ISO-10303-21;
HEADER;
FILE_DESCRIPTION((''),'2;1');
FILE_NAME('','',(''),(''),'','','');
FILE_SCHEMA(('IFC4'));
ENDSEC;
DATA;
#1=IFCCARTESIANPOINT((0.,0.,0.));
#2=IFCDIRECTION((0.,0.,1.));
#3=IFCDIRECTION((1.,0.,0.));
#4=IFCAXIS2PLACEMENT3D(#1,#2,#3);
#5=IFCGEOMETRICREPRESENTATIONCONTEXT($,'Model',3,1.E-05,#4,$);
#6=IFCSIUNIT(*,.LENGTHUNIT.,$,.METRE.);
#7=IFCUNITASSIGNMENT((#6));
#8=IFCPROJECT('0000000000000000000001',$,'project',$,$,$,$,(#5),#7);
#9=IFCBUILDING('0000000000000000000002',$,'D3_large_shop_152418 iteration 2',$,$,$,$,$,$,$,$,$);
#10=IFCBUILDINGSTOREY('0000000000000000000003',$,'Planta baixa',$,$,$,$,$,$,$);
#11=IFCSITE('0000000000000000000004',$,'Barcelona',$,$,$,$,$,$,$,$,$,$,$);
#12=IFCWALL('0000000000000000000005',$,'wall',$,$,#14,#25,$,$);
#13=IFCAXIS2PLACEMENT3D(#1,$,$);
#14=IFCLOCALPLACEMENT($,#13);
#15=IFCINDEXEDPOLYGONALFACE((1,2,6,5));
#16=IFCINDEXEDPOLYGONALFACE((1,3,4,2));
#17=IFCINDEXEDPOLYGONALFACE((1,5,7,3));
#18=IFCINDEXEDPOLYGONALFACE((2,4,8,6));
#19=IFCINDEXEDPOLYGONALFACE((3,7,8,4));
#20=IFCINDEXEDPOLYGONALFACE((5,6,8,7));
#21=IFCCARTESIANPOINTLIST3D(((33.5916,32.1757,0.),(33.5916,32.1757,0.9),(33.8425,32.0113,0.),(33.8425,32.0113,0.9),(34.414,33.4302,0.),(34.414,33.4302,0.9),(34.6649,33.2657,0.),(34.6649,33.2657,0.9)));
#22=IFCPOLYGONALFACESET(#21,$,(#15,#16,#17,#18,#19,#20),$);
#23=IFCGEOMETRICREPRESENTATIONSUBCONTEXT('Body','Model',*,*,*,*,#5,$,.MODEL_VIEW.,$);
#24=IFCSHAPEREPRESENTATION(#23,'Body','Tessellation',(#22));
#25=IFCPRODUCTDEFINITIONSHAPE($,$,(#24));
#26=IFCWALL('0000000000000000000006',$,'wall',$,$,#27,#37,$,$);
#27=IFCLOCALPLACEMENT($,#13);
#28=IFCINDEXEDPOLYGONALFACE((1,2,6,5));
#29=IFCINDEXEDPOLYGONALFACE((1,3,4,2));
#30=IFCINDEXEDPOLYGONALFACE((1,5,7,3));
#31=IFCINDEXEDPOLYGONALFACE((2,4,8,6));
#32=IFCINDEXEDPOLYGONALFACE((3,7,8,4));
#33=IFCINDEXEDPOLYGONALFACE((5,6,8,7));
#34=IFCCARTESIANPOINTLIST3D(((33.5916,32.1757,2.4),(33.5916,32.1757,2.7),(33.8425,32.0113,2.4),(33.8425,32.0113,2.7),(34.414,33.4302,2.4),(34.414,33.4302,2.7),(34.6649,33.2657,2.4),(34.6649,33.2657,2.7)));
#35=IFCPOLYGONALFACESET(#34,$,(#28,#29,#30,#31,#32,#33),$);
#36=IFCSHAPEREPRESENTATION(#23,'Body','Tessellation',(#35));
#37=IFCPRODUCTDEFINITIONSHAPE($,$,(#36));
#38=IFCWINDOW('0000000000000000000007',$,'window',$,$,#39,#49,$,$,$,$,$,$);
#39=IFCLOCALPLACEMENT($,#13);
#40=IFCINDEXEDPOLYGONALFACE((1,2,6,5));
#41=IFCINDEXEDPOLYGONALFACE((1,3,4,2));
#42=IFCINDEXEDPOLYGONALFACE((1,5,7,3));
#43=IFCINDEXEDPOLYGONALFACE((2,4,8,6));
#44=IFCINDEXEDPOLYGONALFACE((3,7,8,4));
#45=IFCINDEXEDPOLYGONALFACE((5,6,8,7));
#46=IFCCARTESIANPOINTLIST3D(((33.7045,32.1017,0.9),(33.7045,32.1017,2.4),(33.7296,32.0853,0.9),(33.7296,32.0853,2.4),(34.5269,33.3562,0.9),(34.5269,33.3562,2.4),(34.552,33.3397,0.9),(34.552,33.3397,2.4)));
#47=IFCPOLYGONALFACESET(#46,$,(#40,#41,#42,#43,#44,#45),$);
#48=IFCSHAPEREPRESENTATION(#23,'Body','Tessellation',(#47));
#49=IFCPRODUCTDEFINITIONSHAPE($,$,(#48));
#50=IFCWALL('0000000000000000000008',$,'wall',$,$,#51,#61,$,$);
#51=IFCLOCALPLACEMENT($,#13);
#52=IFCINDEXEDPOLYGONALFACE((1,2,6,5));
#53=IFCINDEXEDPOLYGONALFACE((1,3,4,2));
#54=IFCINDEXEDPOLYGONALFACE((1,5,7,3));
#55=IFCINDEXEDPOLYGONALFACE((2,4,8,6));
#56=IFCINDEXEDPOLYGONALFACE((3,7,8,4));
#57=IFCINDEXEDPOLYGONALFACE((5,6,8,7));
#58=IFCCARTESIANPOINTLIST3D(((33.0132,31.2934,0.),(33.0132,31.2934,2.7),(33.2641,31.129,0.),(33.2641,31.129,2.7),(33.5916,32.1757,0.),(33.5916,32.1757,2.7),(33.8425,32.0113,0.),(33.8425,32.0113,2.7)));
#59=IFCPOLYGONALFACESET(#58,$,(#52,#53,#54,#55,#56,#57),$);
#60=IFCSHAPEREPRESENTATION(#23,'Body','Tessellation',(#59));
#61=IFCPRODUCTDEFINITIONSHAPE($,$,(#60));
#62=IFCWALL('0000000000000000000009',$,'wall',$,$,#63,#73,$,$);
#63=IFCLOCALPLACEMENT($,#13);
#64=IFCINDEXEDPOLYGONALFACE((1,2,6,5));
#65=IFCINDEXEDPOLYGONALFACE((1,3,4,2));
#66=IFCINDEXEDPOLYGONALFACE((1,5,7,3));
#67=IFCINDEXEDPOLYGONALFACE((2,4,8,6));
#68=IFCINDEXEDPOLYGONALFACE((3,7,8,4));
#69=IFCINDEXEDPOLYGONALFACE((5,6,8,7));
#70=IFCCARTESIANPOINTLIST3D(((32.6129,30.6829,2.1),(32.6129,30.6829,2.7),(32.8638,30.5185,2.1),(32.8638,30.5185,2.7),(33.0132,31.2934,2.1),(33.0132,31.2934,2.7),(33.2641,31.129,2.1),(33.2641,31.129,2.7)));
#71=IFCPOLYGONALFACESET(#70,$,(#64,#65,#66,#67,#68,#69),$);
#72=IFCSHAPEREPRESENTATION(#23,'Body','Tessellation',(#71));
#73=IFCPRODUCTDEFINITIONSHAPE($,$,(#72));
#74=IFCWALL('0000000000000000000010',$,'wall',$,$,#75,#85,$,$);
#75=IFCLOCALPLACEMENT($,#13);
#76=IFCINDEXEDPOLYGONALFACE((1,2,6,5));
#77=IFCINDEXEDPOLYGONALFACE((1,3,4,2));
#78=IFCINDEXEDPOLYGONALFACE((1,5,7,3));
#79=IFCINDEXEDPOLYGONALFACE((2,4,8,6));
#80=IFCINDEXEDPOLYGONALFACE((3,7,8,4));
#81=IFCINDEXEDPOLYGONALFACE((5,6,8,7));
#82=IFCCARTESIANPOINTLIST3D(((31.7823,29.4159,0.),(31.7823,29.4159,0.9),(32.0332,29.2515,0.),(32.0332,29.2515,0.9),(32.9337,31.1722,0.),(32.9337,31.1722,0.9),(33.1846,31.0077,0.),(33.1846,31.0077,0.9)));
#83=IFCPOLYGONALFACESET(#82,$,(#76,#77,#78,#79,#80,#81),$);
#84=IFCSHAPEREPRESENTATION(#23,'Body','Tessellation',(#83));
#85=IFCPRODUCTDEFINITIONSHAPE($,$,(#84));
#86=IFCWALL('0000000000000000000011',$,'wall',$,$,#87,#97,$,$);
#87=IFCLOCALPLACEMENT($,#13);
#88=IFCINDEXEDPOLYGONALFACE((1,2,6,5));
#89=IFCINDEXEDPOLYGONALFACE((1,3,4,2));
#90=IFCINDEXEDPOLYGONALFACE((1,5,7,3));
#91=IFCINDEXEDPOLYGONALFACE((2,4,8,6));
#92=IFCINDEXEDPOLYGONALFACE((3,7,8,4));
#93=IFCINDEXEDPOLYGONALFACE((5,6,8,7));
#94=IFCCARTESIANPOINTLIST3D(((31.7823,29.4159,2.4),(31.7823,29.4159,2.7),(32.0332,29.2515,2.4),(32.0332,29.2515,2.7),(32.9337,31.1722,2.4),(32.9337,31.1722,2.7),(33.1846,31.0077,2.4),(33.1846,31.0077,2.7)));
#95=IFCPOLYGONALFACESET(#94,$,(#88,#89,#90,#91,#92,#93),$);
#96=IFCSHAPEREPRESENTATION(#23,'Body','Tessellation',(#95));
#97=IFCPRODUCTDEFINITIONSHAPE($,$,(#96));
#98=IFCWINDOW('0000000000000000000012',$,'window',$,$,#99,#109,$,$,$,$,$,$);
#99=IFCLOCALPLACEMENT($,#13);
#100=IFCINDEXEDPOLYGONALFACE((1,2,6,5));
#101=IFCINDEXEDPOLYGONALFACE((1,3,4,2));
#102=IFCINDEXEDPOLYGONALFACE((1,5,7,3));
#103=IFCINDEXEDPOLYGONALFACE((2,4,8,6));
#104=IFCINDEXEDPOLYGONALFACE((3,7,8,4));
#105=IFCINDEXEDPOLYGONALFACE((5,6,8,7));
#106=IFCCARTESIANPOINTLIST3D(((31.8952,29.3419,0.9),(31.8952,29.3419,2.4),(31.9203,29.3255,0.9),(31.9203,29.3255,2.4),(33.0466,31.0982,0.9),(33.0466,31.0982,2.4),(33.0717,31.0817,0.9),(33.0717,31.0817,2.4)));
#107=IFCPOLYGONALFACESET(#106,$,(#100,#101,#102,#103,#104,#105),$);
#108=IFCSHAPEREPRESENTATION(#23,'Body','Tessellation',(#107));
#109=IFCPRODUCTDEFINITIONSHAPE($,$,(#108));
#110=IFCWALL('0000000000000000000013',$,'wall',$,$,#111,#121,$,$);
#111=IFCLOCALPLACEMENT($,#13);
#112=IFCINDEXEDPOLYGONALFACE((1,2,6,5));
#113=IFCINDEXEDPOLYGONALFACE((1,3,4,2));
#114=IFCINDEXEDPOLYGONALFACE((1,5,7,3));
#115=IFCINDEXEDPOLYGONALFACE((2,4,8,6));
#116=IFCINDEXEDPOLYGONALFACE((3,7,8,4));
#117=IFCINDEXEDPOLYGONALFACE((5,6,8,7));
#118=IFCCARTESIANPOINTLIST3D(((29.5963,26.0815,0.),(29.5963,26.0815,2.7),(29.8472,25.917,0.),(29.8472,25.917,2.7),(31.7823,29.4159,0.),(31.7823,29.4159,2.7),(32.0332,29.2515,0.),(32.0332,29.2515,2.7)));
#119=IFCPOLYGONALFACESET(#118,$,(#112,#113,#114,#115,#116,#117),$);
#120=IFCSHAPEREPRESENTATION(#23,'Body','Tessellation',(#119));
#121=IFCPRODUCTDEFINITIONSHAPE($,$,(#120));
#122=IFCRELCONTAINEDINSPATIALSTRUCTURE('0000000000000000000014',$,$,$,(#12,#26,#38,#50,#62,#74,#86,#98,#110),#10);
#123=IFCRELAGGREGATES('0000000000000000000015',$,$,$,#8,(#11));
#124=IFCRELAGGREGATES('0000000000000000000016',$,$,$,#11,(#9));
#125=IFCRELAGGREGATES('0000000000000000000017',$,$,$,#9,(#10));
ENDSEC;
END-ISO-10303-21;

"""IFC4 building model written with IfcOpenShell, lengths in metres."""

from ifc_helpers import new_model, si_unit, frame, origin, origin_with_axes, place, context, subcontext, project, spatial, polyline, outline, extrude, element, save


model = new_model("IFC4")

# Units and contexts
model_context = context("Model", 3, precision=1e-05, world=origin_with_axes())
body_context = subcontext(model_context, "Body", "Model", "MODEL_VIEW")
ifc_project = project(units=[si_unit("LENGTHUNIT", "METRE")], contexts=[model_context])

# Site, building, storey
site = spatial("IfcSite", under=ifc_project, Name="Barcelona")
building = spatial("IfcBuilding", under=site, Name="D3_large_shop_152418 iteration 2")
storey = spatial("IfcBuildingStorey", under=building, Name="Planta baixa")

# Walls
wall_1_placement = place(None, origin_with_axes())
element("IfcWall", 1, at=wall_1_placement, inside=storey, Name="wall", context=body_context, shape_type="SweptSolid", body=[
    extrude(outline(polyline([(34.6649, 33.2657), (33.8425, 32.0113), (33.5916, 32.1757), (34.414, 33.4302), (34.6649, 33.2657)])), origin(), (0.0, 0.0, 1.0), 0.9),
])
wall_2_placement = place(None, origin_with_axes())
element("IfcWall", 2, at=wall_2_placement, inside=storey, Name="wall", context=body_context, shape_type="SweptSolid", body=[
    extrude(outline(polyline([(34.6649, 33.2657), (33.8425, 32.0113), (33.5916, 32.1757), (34.414, 33.4302), (34.6649, 33.2657)])), frame((0.0, 0.0, 2.4)), (0.0, 0.0, 1.0), 0.3),
])

# Window
window_1_placement = place(None, origin_with_axes())
element("IfcWindow", 3, at=window_1_placement, inside=storey, Name="window", context=body_context, shape_type="SweptSolid", body=[
    extrude(outline(polyline([(34.552, 33.3397), (33.7296, 32.0853), (33.7045, 32.1017), (34.5269, 33.3562), (34.552, 33.3397)])), frame((0.0, 0.0, 0.9)), (0.0, 0.0, 1.0), 1.5),
])

# Walls
wall_3_placement = place(None, origin_with_axes())
element("IfcWall", 4, at=wall_3_placement, inside=storey, Name="wall", context=body_context, shape_type="SweptSolid", body=[
    extrude(outline(polyline([(33.8425, 32.0113), (33.2641, 31.129), (33.0132, 31.2934), (33.5916, 32.1757), (33.8425, 32.0113)])), origin(), (0.0, 0.0, 1.0), 2.7),
])
wall_4_placement = place(None, origin_with_axes())
element("IfcWall", 5, at=wall_4_placement, inside=storey, Name="wall", context=body_context, shape_type="SweptSolid", body=[
    extrude(outline(polyline([(33.2641, 31.129), (32.8638, 30.5185), (32.6129, 30.6829), (33.0132, 31.2934), (33.2641, 31.129)])), frame((0.0, 0.0, 2.1)), (0.0, 0.0, 1.0), 0.6),
])
wall_5_placement = place(None, origin_with_axes())
element("IfcWall", 6, at=wall_5_placement, inside=storey, Name="wall", context=body_context, shape_type="SweptSolid", body=[
    extrude(outline(polyline([(33.1846, 31.0077), (32.0332, 29.2515), (31.7823, 29.4159), (32.9337, 31.1722), (33.1846, 31.0077)])), origin(), (0.0, 0.0, 1.0), 0.9),
])
wall_6_placement = place(None, origin_with_axes())
element("IfcWall", 7, at=wall_6_placement, inside=storey, Name="wall", context=body_context, shape_type="SweptSolid", body=[
    extrude(outline(polyline([(33.1846, 31.0077), (32.0332, 29.2515), (31.7823, 29.4159), (32.9337, 31.1722), (33.1846, 31.0077)])), frame((0.0, 0.0, 2.4)), (0.0, 0.0, 1.0), 0.3),
])

# Window
window_2_placement = place(None, origin_with_axes())
element("IfcWindow", 8, at=window_2_placement, inside=storey, Name="window", context=body_context, shape_type="SweptSolid", body=[
    extrude(outline(polyline([(33.0717, 31.0817), (31.9203, 29.3255), (31.8952, 29.3419), (33.0466, 31.0982), (33.0717, 31.0817)])), frame((0.0, 0.0, 0.9)), (0.0, 0.0, 1.0), 1.5),
])

# Wall
wall_7_placement = place(None, origin_with_axes())
element("IfcWall", 9, at=wall_7_placement, inside=storey, Name="wall", context=body_context, shape_type="SweptSolid", body=[
    extrude(outline(polyline([(32.0332, 29.2515), (29.8472, 25.917), (29.5963, 26.0815), (31.7823, 29.4159), (32.0332, 29.2515)])), origin(), (0.0, 0.0, 1.0), 2.7),
])

save(model, "model.ifc")
